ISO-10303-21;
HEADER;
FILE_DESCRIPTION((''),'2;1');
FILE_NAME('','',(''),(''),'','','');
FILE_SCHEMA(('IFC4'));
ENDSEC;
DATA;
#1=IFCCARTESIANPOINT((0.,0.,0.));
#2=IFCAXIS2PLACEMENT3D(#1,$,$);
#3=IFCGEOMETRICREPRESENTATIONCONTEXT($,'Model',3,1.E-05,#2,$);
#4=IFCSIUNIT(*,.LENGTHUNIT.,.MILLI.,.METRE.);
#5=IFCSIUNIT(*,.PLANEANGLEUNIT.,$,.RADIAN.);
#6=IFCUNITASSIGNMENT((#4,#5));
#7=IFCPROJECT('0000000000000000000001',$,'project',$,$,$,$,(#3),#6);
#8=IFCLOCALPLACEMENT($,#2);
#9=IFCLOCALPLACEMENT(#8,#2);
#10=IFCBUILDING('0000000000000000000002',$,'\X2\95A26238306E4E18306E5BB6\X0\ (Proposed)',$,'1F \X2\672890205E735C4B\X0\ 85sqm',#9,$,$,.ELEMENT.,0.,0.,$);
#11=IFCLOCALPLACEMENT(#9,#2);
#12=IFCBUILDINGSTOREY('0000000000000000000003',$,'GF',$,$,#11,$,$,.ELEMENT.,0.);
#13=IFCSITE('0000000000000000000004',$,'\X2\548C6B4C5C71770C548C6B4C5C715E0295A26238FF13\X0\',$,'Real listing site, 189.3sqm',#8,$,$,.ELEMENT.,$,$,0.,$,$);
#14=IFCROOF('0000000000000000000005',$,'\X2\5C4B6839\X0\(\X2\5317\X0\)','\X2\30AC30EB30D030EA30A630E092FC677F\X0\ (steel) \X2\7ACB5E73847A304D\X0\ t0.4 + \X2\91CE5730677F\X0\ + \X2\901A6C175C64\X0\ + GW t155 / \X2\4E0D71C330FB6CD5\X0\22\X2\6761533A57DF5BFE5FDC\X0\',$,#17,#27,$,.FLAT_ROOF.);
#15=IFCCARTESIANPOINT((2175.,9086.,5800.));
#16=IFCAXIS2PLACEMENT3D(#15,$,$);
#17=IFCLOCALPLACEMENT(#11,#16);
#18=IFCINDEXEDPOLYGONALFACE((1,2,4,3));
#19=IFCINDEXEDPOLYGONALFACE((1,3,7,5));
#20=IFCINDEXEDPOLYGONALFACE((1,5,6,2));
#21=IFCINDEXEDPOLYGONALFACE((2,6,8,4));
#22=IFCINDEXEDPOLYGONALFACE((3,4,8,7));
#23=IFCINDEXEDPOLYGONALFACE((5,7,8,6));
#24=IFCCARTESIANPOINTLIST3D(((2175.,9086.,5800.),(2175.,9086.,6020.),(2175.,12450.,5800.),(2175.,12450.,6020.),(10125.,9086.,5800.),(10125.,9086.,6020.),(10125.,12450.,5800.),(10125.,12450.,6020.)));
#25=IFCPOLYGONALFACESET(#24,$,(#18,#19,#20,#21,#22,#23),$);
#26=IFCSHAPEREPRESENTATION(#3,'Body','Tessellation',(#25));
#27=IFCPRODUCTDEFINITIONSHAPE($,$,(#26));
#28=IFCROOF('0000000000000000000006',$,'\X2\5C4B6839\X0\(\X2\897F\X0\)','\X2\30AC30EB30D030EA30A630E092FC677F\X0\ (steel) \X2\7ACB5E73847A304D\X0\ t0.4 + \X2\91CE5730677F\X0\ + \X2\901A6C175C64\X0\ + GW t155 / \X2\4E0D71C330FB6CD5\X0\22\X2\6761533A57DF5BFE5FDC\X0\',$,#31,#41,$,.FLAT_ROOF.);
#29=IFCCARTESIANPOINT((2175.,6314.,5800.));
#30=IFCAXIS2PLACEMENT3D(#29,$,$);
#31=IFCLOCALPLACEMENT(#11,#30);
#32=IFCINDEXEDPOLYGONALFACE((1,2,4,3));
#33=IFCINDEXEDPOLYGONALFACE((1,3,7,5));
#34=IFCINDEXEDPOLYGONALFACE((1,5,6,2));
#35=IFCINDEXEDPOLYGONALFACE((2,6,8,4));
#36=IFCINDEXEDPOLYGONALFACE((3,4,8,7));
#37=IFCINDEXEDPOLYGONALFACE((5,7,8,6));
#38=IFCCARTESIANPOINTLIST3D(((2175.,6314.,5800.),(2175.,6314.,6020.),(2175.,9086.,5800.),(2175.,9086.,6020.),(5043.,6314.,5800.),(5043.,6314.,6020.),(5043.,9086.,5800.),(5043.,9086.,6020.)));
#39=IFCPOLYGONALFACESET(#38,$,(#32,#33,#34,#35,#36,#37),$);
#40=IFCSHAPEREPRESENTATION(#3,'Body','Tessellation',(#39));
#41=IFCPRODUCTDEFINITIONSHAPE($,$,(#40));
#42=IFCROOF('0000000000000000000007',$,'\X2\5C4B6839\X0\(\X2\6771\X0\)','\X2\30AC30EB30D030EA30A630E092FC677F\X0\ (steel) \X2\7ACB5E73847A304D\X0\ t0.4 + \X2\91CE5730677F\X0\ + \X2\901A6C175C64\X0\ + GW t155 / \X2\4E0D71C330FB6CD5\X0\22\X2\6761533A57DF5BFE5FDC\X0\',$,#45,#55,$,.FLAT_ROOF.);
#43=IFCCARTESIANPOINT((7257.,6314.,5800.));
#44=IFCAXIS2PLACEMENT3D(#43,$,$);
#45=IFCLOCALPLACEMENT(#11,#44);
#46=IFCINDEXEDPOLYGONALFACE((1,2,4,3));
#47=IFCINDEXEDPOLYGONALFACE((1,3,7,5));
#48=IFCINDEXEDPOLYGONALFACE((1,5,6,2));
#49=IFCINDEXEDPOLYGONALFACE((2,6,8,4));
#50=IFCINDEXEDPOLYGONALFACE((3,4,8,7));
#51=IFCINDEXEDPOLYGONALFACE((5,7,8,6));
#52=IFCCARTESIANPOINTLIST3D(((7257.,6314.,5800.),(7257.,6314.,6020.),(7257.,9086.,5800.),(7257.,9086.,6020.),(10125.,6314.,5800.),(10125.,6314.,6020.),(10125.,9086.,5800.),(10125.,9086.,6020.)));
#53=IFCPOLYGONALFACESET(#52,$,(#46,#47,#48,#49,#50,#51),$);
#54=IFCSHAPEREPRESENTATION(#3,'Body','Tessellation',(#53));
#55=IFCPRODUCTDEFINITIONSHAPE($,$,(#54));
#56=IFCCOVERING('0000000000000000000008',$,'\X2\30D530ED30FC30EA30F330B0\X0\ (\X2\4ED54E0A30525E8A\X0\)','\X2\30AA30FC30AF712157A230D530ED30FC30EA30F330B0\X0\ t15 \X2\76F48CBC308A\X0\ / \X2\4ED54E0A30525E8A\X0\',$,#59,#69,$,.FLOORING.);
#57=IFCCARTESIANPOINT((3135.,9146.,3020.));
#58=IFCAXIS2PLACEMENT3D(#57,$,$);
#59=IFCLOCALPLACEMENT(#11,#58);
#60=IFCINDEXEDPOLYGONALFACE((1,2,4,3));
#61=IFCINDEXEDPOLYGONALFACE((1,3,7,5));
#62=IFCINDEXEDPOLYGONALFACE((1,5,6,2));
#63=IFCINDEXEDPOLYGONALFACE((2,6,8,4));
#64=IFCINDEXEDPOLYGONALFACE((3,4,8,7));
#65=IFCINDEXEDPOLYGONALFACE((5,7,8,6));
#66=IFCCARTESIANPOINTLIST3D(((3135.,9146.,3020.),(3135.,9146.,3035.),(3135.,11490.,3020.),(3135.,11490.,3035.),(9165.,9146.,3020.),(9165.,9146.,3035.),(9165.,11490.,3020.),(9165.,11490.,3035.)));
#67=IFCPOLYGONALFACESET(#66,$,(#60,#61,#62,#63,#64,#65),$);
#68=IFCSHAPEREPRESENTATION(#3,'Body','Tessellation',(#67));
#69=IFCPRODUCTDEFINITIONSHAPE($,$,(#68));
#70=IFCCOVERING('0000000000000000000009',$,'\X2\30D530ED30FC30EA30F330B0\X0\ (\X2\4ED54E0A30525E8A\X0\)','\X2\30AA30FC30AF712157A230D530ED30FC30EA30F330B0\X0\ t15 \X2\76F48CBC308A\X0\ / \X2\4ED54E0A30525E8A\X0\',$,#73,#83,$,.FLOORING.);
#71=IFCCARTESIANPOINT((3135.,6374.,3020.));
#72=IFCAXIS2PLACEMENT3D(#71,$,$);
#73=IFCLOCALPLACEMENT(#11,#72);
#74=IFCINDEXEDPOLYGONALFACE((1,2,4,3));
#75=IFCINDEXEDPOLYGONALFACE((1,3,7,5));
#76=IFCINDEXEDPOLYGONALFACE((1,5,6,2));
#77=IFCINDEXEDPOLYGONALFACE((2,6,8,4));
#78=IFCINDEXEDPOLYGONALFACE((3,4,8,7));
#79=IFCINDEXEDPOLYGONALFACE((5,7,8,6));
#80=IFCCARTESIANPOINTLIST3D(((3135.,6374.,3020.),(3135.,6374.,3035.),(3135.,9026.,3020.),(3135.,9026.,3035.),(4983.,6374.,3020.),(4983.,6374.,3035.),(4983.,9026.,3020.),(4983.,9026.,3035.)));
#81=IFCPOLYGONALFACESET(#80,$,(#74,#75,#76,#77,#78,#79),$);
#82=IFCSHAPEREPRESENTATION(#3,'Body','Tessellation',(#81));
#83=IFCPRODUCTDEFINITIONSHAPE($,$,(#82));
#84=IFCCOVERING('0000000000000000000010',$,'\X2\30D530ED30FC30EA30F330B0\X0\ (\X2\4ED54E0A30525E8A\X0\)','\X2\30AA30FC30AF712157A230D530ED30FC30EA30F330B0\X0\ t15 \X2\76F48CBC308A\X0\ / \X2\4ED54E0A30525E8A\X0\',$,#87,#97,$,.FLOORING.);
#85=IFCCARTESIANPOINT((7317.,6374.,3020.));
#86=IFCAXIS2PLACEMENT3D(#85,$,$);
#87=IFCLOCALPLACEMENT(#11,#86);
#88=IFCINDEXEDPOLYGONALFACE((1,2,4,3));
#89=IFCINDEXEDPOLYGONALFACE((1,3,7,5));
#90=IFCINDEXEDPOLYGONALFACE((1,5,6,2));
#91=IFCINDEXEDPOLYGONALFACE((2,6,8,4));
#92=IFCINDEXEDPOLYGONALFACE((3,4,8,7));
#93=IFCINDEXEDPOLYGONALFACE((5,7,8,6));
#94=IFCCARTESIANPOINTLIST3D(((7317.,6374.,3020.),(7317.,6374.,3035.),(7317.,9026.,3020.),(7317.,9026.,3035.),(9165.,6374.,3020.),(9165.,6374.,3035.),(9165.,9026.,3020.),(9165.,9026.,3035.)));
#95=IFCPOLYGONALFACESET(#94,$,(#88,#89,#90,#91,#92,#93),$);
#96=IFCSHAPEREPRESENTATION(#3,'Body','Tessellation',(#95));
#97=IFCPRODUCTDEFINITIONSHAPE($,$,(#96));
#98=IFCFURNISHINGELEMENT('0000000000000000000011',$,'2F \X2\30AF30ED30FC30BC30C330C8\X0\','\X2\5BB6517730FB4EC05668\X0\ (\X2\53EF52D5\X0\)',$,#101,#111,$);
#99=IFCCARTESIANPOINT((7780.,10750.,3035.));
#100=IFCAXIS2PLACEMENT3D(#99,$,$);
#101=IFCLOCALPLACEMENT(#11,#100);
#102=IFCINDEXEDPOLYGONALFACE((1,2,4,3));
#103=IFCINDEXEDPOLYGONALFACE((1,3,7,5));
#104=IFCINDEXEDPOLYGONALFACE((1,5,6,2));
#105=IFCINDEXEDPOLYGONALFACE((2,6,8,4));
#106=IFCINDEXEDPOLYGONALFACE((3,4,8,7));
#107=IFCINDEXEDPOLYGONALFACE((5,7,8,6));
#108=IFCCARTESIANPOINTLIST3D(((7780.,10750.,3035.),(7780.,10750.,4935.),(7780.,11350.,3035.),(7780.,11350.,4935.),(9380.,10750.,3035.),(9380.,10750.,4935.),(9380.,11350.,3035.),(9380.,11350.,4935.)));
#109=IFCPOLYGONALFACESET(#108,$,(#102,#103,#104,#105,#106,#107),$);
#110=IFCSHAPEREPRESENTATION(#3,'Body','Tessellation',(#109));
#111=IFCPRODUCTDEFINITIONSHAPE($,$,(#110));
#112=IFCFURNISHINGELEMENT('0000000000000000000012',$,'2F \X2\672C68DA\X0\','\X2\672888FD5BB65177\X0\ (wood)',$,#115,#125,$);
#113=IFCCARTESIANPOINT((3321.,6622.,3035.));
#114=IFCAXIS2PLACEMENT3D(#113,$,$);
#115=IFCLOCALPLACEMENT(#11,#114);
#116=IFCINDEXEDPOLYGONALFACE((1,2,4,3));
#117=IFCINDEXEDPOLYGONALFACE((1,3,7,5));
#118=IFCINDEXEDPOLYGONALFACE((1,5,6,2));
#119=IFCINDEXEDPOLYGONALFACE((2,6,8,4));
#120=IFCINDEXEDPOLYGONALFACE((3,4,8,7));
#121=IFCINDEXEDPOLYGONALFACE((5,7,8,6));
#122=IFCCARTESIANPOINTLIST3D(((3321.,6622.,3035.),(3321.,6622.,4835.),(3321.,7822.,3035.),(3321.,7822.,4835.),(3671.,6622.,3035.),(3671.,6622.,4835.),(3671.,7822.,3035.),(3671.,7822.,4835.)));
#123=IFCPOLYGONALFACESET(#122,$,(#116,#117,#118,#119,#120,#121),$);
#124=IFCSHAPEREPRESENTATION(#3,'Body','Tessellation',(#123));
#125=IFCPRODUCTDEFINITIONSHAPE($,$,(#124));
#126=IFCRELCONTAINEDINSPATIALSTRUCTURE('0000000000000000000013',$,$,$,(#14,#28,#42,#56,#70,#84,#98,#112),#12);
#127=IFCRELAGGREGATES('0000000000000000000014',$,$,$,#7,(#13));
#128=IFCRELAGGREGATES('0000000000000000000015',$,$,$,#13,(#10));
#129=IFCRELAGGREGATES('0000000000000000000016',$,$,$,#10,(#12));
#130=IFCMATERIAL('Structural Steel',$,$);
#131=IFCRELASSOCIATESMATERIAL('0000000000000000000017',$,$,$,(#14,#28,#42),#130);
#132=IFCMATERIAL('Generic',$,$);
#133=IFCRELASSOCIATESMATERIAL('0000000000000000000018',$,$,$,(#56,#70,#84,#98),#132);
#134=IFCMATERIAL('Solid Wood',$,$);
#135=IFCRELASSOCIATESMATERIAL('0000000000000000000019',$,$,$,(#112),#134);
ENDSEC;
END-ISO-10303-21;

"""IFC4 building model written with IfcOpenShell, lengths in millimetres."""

from ifc_helpers import new_model, si_unit, frame, frame_2d, origin, place, context, project, spatial, rectangle, extrude, material, element, save


model = new_model("IFC4")

# Units and contexts
model_context = context("Model", 3, precision=1e-05, world=origin())
ifc_project = project(units=[si_unit("LENGTHUNIT", "METRE", prefix="MILLI"), si_unit("PLANEANGLEUNIT", "RADIAN")], contexts=[model_context])

# Site, building, storey
site_placement = place(None, origin())
site = spatial("IfcSite", under=ifc_project, at=site_placement, Name="和歌山県和歌山市関戸３", ObjectType="Real listing site, 189.3sqm", CompositionType="ELEMENT", RefElevation=0.0)
building_placement = place(site_placement, origin())
building = spatial("IfcBuilding", under=site, at=building_placement, Name="関戸の丘の家 (Proposed)", ObjectType="1F 木造平屋 85sqm", CompositionType="ELEMENT", ElevationOfRefHeight=0.0, ElevationOfTerrain=0.0)
storey_placement = place(building_placement, origin())
storey = spatial("IfcBuildingStorey", under=building, at=storey_placement, Name="GF", CompositionType="ELEMENT", Elevation=0.0)

# Shared definitions
ifc_material_1 = material(Name="Solid Wood")

# Shared definitions
ifc_material_2 = material(Name="Generic")

# Roofs
ifc_material_3 = material(Name="Structural Steel")
for number, where, name in (
    (1, (2175.0, 9086.0, 5800.0), "屋根(北)"),
):
    element("IfcRoof", number, at=place(storey_placement, frame(where)), inside=storey, material=ifc_material_3, Name=name, Description="ガルバリウム鋼板 (steel) 立平葺き t0.4 + 野地板 + 通気層 + GW t155 / 不燃・法22条区域対応", PredefinedType="FLAT_ROOF", context=model_context, shape_type="SweptSolid", body=[
        extrude(rectangle(XDim=7950.0, YDim=3364.0, at=frame_2d((3975.0, 1682.0))), frame((2175.0, 9086.0, 5800.0)), (0.0, 0.0, 1.0), 220.0),
    ])
roof_1_placement = place(storey_placement, frame((2175.0, 6314.0, 5800.0)))
element("IfcRoof", 2, at=roof_1_placement, inside=storey, material=ifc_material_3, Name="屋根(西)", Description="ガルバリウム鋼板 (steel) 立平葺き t0.4 + 野地板 + 通気層 + GW t155 / 不燃・法22条区域対応", PredefinedType="FLAT_ROOF", context=model_context, shape_type="SweptSolid", body=[
    extrude(rectangle(XDim=2868.0, YDim=2772.0, at=frame_2d((1434.0, 1386.0))), frame((2175.0, 6314.0, 5800.0)), (0.0, 0.0, 1.0), 220.0),
])
roof_2_placement = place(storey_placement, frame((7257.0, 6314.0, 5800.0)))
element("IfcRoof", 3, at=roof_2_placement, inside=storey, material=ifc_material_3, Name="屋根(東)", Description="ガルバリウム鋼板 (steel) 立平葺き t0.4 + 野地板 + 通気層 + GW t155 / 不燃・法22条区域対応", PredefinedType="FLAT_ROOF", context=model_context, shape_type="SweptSolid", body=[
    extrude(rectangle(XDim=2868.0, YDim=2772.0, at=frame_2d((1434.0, 1386.0))), frame((7257.0, 6314.0, 5800.0)), (0.0, 0.0, 1.0), 220.0),
])

# Coverings
covering_1_placement = place(storey_placement, frame((3135.0, 9146.0, 3020.0)))
element("IfcCovering", 4, at=covering_1_placement, inside=storey, material=ifc_material_2, Name="フローリング (仕上げ床)", Description="オーク無垢フローリング t15 直貼り / 仕上げ床", PredefinedType="FLOORING", context=model_context, shape_type="SweptSolid", body=[
    extrude(rectangle(XDim=6030.0, YDim=2344.0, at=frame_2d((3015.0, 1172.0))), frame((3135.0, 9146.0, 3020.0)), (0.0, 0.0, 1.0), 15.0),
])
covering_2_placement = place(storey_placement, frame((3135.0, 6374.0, 3020.0)))
element("IfcCovering", 5, at=covering_2_placement, inside=storey, material=ifc_material_2, Name="フローリング (仕上げ床)", Description="オーク無垢フローリング t15 直貼り / 仕上げ床", PredefinedType="FLOORING", context=model_context, shape_type="SweptSolid", body=[
    extrude(rectangle(XDim=1848.0, YDim=2652.0, at=frame_2d((924.0, 1326.0))), frame((3135.0, 6374.0, 3020.0)), (0.0, 0.0, 1.0), 15.0),
])
covering_3_placement = place(storey_placement, frame((7317.0, 6374.0, 3020.0)))
element("IfcCovering", 6, at=covering_3_placement, inside=storey, material=ifc_material_2, Name="フローリング (仕上げ床)", Description="オーク無垢フローリング t15 直貼り / 仕上げ床", PredefinedType="FLOORING", context=model_context, shape_type="SweptSolid", body=[
    extrude(rectangle(XDim=1848.0, YDim=2652.0, at=frame_2d((924.0, 1326.0))), frame((7317.0, 6374.0, 3020.0)), (0.0, 0.0, 1.0), 15.0),
])

# Furnishing elements
furnishing_1_placement = place(storey_placement, frame((7780.0, 10750.0, 3035.0)))
element("IfcFurnishingElement", 7, at=furnishing_1_placement, inside=storey, material=ifc_material_2, Name="2F クローゼット", Description="家具・什器 (可動)", context=model_context, shape_type="SweptSolid", body=[
    extrude(rectangle(XDim=1600.0, YDim=600.0, at=frame_2d((800.0, 300.0))), frame((7780.0, 10750.0, 3035.0)), (0.0, 0.0, 1.0), 1900.0),
])
furnishing_2_placement = place(storey_placement, frame((3321.0, 6622.0, 3035.0)))
element("IfcFurnishingElement", 8, at=furnishing_2_placement, inside=storey, material=ifc_material_1, Name="2F 本棚", Description="木製家具 (wood)", context=model_context, shape_type="SweptSolid", body=[
    extrude(rectangle(XDim=350.0, YDim=1200.0, at=frame_2d((175.0, 600.0))), frame((3321.0, 6622.0, 3035.0)), (0.0, 0.0, 1.0), 1800.0),
])

save(model, "model.ifc")
